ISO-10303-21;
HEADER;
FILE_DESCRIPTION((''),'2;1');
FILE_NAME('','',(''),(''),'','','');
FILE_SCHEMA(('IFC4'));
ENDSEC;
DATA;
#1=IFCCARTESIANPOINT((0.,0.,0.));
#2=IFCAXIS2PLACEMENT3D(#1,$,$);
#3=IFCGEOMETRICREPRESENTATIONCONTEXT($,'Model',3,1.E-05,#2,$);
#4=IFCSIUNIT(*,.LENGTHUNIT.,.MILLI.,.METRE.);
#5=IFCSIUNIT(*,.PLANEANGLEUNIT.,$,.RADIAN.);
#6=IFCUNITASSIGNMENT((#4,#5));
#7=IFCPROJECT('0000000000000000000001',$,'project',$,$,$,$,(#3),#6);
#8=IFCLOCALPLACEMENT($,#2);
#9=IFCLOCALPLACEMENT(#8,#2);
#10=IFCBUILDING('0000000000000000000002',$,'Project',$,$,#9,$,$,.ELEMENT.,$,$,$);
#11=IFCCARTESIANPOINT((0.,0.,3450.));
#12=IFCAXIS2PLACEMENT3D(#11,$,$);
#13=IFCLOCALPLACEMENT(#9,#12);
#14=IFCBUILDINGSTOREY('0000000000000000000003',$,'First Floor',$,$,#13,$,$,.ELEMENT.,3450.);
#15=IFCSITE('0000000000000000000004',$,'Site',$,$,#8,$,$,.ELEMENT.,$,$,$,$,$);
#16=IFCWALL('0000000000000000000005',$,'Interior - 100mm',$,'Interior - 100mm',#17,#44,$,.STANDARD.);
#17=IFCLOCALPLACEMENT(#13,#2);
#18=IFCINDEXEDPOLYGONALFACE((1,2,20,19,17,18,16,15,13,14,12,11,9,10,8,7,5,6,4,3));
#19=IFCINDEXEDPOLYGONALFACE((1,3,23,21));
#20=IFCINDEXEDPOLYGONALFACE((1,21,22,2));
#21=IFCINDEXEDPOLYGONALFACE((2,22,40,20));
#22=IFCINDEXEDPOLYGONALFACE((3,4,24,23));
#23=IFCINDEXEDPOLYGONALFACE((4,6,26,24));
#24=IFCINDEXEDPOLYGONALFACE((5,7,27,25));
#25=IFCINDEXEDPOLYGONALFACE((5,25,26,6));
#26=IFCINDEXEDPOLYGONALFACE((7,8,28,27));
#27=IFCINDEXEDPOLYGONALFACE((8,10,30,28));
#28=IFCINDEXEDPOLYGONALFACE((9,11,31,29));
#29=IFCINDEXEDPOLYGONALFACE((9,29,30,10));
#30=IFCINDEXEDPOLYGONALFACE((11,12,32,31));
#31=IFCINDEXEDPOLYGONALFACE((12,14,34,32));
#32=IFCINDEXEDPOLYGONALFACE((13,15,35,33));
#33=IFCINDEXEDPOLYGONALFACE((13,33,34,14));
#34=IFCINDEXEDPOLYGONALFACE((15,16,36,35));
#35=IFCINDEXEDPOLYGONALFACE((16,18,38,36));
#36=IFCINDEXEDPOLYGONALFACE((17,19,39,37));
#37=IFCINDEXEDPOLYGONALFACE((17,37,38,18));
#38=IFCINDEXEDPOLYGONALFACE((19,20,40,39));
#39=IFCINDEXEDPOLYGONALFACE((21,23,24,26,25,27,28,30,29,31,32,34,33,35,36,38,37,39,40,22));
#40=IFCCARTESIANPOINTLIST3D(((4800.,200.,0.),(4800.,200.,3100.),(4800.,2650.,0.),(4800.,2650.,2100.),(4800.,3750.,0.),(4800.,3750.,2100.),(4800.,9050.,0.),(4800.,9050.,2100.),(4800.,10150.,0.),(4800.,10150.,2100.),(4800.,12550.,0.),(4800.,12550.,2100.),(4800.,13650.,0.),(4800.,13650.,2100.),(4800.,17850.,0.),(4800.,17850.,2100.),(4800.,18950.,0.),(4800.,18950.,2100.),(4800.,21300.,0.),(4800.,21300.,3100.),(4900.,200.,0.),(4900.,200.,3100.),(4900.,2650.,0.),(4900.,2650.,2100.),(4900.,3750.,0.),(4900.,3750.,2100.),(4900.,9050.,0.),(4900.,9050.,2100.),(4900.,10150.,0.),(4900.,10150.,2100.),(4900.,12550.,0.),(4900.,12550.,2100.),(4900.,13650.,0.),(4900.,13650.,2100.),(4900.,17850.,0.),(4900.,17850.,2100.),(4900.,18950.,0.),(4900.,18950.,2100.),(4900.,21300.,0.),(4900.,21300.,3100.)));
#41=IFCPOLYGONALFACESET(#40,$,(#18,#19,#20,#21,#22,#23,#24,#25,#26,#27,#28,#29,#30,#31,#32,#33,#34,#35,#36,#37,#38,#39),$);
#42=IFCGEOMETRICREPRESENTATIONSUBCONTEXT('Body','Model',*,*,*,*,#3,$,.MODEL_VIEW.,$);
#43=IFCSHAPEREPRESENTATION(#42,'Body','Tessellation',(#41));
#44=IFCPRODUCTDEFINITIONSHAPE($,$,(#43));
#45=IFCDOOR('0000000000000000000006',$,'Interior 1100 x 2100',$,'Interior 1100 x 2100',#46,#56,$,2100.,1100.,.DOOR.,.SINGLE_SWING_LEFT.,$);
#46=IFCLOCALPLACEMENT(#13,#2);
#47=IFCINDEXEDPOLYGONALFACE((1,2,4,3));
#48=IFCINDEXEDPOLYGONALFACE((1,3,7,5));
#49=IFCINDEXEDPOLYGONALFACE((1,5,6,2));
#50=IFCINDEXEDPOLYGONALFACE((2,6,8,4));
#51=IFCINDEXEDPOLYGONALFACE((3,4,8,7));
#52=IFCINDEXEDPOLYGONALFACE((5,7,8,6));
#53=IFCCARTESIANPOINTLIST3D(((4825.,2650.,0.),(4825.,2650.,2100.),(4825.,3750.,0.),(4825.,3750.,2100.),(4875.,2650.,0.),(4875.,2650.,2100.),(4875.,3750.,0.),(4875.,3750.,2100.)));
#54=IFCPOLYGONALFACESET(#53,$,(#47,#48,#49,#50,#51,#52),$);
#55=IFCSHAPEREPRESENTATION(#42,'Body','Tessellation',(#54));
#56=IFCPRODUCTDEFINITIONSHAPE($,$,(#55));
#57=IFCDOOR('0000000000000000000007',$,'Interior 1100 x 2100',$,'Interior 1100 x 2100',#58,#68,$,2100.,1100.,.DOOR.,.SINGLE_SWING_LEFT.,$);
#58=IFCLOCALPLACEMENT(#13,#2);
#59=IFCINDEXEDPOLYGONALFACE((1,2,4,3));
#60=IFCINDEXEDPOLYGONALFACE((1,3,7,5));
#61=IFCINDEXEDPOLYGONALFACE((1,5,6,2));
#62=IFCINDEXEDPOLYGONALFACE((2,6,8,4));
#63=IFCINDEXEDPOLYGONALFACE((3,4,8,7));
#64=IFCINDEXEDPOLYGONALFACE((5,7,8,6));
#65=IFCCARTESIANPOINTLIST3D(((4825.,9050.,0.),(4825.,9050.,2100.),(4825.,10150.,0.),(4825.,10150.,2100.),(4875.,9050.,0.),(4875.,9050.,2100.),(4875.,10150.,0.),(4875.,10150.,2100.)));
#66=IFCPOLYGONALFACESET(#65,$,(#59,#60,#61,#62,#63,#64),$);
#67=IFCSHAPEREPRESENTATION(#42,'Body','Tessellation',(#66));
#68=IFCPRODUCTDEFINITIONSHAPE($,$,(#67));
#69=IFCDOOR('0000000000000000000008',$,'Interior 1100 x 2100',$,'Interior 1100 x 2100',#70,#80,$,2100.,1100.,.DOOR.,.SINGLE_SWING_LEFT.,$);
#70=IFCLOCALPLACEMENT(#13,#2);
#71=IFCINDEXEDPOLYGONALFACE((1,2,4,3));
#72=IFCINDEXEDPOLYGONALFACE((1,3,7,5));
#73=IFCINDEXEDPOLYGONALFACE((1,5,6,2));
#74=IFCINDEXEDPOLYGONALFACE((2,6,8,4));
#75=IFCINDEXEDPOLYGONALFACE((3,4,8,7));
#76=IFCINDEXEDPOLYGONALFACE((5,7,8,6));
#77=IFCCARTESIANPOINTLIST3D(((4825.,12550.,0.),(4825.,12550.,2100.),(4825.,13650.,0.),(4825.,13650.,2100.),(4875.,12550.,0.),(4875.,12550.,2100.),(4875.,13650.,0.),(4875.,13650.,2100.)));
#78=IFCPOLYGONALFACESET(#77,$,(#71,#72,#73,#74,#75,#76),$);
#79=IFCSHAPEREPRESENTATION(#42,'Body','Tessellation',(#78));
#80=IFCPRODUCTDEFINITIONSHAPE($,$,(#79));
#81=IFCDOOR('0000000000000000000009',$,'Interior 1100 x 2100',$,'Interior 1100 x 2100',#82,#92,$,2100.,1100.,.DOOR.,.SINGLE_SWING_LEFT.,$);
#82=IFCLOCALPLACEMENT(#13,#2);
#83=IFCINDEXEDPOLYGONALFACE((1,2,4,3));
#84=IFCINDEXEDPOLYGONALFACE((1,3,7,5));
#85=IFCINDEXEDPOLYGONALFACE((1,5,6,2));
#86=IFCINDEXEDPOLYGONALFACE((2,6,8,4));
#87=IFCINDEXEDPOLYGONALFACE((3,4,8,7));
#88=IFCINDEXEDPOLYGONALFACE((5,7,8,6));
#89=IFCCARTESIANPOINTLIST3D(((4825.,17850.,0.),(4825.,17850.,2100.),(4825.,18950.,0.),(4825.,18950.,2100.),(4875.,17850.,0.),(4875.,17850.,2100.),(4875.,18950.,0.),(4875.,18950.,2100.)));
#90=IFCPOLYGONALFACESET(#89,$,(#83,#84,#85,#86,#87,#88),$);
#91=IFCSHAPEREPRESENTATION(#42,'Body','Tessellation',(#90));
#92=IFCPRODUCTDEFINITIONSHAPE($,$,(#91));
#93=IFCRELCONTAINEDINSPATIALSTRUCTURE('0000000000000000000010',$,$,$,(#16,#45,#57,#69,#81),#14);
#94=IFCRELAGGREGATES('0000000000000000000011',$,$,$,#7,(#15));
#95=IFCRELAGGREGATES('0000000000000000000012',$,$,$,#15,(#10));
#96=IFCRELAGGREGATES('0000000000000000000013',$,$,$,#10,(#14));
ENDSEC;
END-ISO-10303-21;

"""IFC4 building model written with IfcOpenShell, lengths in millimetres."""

from ifc_helpers import new_model, si_unit, frame, frame_2d, origin, place, context, subcontext, project, spatial, polyline, rectangle, outline, extrude, element, fill, save


model = new_model("IFC4")

# Units and contexts
model_context = context("Model", 3, precision=1e-05, world=origin())
body_context = subcontext(model_context, "Body", "Model", "MODEL_VIEW")
ifc_project = project(units=[si_unit("LENGTHUNIT", "METRE", prefix="MILLI"), si_unit("PLANEANGLEUNIT", "RADIAN")], contexts=[model_context])

# Site, building, storey
site_placement = place(None, origin())
site = spatial("IfcSite", under=ifc_project, at=site_placement, Name="Site", CompositionType="ELEMENT")
building_placement = place(site_placement, origin())
building = spatial("IfcBuilding", under=site, at=building_placement, Name="Project", CompositionType="ELEMENT")
storey_placement = place(building_placement, frame((0.0, 0.0, 3450.0)))
storey = spatial("IfcBuildingStorey", under=building, at=storey_placement, Name="First Floor", CompositionType="ELEMENT", Elevation=3450.0)

# Wall, openings, doors
wall_1_placement = place(storey_placement, frame((4850.0, 200.0, 0.0), z_axis=(0.0, 0.0, 1.0), x_axis=(0.0, 1.0, 0.0)))
wall_1 = element("IfcWall", 1, at=wall_1_placement, inside=storey, Name="Interior - 100mm", ObjectType="Interior - 100mm", PredefinedType="STANDARD", context=body_context, shape_type="SweptSolid", body=[
    extrude(outline(polyline([(0.0, -50.0), (0.0, 50.0), (21100.0, 50.0), (21100.0, -50.0), (0.0, -50.0)])), origin(), (0.0, 0.0, 1.0), 3100.0),
])
opening_1_placement = place(wall_1_placement, frame((2450.0, 0.0, 0.0), z_axis=(0.0, 0.0, 1.0), x_axis=(1.0, 0.0, 0.0)))
opening_1 = element("IfcOpeningElement", 2, at=opening_1_placement, cuts=wall_1, PredefinedType="OPENING", context=body_context, shape_type="SweptSolid", body=[
    extrude(rectangle(XDim=1100.0, YDim=120.0, at=frame_2d((550.0, 0.0))), origin(), (0.0, 0.0, 1.0), 2100.0),
])
opening_2_placement = place(wall_1_placement, frame((8850.0, 0.0, 0.0), z_axis=(0.0, 0.0, 1.0), x_axis=(1.0, 0.0, 0.0)))
opening_2 = element("IfcOpeningElement", 3, at=opening_2_placement, cuts=wall_1, PredefinedType="OPENING", context=body_context, shape_type="SweptSolid", body=[
    extrude(rectangle(XDim=1100.0, YDim=120.0, at=frame_2d((550.0, 0.0))), origin(), (0.0, 0.0, 1.0), 2100.0),
])
opening_3_placement = place(wall_1_placement, frame((12350.0, 0.0, 0.0), z_axis=(0.0, 0.0, 1.0), x_axis=(1.0, 0.0, 0.0)))
opening_3 = element("IfcOpeningElement", 4, at=opening_3_placement, cuts=wall_1, PredefinedType="OPENING", context=body_context, shape_type="SweptSolid", body=[
    extrude(rectangle(XDim=1100.0, YDim=120.0, at=frame_2d((550.0, 0.0))), origin(), (0.0, 0.0, 1.0), 2100.0),
])
opening_4_placement = place(wall_1_placement, frame((17650.0, 0.0, 0.0), z_axis=(0.0, 0.0, 1.0), x_axis=(1.0, 0.0, 0.0)))
opening_4 = element("IfcOpeningElement", 5, at=opening_4_placement, cuts=wall_1, PredefinedType="OPENING", context=body_context, shape_type="SweptSolid", body=[
    extrude(rectangle(XDim=1100.0, YDim=120.0, at=frame_2d((550.0, 0.0))), origin(), (0.0, 0.0, 1.0), 2100.0),
])
door_1_placement = place(opening_1_placement, origin())
door_1 = element("IfcDoor", 6, at=door_1_placement, inside=storey, Name="Interior 1100 x 2100", ObjectType="Interior 1100 x 2100", OperationType="SINGLE_SWING_LEFT", OverallHeight=2100.0, OverallWidth=1100.0, PredefinedType="DOOR", context=body_context, shape_type="SweptSolid", body=[
    extrude(rectangle(XDim=1100.0, YDim=50.0, at=frame_2d((550.0, 0.0))), origin(), (0.0, 0.0, 1.0), 2100.0),
])
fill(opening_1, door_1)
door_2_placement = place(opening_2_placement, origin())
door_2 = element("IfcDoor", 7, at=door_2_placement, inside=storey, Name="Interior 1100 x 2100", ObjectType="Interior 1100 x 2100", OperationType="SINGLE_SWING_LEFT", OverallHeight=2100.0, OverallWidth=1100.0, PredefinedType="DOOR", context=body_context, shape_type="SweptSolid", body=[
    extrude(rectangle(XDim=1100.0, YDim=50.0, at=frame_2d((550.0, 0.0))), origin(), (0.0, 0.0, 1.0), 2100.0),
])
fill(opening_2, door_2)
door_3_placement = place(opening_3_placement, origin())
door_3 = element("IfcDoor", 8, at=door_3_placement, inside=storey, Name="Interior 1100 x 2100", ObjectType="Interior 1100 x 2100", OperationType="SINGLE_SWING_LEFT", OverallHeight=2100.0, OverallWidth=1100.0, PredefinedType="DOOR", context=body_context, shape_type="SweptSolid", body=[
    extrude(rectangle(XDim=1100.0, YDim=50.0, at=frame_2d((550.0, 0.0))), origin(), (0.0, 0.0, 1.0), 2100.0),
])
fill(opening_3, door_3)
door_4_placement = place(opening_4_placement, origin())
door_4 = element("IfcDoor", 9, at=door_4_placement, inside=storey, Name="Interior 1100 x 2100", ObjectType="Interior 1100 x 2100", OperationType="SINGLE_SWING_LEFT", OverallHeight=2100.0, OverallWidth=1100.0, PredefinedType="DOOR", context=body_context, shape_type="SweptSolid", body=[
    extrude(rectangle(XDim=1100.0, YDim=50.0, at=frame_2d((550.0, 0.0))), origin(), (0.0, 0.0, 1.0), 2100.0),
])
fill(opening_4, door_4)

save(model, "model.ifc")
